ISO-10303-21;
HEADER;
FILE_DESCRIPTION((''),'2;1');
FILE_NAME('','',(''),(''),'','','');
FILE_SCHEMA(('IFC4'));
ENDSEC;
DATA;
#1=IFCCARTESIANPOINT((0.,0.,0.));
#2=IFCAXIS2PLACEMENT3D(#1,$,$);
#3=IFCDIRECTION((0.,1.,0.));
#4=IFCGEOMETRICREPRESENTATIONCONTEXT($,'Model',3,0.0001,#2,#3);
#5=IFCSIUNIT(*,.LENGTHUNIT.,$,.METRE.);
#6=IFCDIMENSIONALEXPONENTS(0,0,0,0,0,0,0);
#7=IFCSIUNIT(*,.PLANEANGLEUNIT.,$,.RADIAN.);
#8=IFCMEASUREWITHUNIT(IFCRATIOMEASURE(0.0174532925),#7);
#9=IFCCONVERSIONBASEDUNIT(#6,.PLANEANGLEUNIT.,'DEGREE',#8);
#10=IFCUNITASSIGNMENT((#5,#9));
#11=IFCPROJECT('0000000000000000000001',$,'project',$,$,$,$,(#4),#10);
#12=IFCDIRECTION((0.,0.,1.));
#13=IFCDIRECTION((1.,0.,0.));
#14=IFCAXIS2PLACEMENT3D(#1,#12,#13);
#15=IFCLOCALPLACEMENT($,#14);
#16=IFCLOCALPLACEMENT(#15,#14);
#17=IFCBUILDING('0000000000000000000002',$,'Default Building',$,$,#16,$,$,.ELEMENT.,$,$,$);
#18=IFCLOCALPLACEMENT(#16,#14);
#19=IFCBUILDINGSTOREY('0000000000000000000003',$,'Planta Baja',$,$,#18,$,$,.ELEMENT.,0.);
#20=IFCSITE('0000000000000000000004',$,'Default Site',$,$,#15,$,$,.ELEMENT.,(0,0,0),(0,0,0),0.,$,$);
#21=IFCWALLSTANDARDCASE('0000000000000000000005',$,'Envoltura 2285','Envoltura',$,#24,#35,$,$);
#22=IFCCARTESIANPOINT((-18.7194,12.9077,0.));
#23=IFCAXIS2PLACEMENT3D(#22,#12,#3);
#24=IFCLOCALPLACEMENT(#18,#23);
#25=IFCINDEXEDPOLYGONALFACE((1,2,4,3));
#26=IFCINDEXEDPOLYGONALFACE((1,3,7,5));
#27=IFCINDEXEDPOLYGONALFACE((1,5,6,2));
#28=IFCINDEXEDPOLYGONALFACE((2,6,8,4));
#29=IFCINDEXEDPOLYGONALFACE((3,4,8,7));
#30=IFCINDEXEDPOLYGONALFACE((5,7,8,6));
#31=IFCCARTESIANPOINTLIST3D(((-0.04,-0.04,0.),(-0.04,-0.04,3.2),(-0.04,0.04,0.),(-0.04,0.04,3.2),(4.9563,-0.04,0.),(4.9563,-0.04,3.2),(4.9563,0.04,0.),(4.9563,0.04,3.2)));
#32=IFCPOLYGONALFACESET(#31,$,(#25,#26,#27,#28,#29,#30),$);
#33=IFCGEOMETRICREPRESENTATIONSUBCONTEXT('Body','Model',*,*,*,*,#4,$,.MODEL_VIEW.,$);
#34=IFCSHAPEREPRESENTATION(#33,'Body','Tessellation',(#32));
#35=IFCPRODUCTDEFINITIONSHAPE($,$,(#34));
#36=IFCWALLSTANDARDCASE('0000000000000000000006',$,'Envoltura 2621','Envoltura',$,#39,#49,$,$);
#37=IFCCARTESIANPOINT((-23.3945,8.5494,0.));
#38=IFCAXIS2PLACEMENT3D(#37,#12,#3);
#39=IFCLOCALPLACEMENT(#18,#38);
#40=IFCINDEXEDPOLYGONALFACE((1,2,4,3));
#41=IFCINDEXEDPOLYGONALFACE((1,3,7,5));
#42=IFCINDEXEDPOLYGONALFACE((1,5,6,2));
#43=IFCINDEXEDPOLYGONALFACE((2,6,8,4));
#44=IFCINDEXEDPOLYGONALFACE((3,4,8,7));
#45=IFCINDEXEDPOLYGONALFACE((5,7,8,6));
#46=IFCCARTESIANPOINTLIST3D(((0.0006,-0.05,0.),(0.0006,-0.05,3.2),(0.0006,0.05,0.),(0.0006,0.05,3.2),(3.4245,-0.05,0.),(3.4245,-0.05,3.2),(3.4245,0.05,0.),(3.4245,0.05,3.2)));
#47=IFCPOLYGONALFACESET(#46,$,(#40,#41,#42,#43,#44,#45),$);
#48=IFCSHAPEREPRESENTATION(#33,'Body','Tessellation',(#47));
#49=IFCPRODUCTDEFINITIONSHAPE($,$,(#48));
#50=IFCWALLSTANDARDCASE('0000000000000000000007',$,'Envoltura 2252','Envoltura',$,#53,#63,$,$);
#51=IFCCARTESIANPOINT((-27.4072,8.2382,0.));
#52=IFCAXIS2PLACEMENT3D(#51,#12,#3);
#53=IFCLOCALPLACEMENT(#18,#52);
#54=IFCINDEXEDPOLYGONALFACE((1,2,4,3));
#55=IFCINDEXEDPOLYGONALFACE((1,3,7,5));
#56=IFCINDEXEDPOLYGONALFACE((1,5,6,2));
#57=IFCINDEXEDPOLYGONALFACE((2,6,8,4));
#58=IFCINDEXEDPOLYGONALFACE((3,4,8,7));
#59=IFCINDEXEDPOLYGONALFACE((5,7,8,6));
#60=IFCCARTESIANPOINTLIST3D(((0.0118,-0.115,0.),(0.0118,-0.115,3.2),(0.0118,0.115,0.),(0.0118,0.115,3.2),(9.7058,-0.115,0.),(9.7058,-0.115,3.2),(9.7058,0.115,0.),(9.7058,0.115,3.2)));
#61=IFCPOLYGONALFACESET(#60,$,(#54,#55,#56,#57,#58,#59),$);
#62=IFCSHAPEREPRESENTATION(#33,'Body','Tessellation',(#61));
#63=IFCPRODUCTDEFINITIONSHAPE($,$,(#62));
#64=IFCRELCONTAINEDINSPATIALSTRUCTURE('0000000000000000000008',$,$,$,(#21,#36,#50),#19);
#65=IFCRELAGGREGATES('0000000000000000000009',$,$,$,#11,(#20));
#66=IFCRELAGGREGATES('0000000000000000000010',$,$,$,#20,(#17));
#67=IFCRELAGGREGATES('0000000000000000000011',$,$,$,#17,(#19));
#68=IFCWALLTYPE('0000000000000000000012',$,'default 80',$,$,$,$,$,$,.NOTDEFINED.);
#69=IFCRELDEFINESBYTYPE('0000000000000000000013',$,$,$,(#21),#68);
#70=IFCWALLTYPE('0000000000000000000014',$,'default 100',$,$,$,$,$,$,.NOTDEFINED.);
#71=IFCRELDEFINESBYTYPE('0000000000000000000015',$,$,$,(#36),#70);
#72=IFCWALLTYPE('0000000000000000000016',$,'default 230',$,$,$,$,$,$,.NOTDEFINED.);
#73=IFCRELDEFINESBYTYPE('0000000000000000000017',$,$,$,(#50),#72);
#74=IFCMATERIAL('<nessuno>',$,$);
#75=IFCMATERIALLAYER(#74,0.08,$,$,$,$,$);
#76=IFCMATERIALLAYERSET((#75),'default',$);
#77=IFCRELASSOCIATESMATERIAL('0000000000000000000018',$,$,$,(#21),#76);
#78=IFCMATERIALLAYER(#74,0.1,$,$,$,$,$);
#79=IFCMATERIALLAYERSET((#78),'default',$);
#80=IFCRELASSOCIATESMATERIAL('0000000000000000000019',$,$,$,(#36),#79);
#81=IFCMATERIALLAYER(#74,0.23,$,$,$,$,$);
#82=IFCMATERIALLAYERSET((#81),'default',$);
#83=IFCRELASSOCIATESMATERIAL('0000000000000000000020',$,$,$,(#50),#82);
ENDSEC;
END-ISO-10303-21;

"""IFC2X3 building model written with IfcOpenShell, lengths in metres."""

from ifc_helpers import new_model, entity, si_unit, converted_unit, direction, frame, origin, origin_with_axes, origin_2d_with_axis, place, context, subcontext, project, spatial, rectangle, extrude, material, layer, layer_set, layer_usage, type_object, element, save


model = new_model("IFC2X3")

# Units and contexts
model_context = context("Model", 3, precision=0.0001, world=origin(), true_north=direction((0.0, 1.0, 0.0)))
body_context = subcontext(model_context, "Body", "Model", "MODEL_VIEW")
ifc_project = project(units=[si_unit("LENGTHUNIT", "METRE"), converted_unit("PLANEANGLEUNIT", "DEGREE", entity("IfcRatioMeasure", 0.0174532925), si_unit("PLANEANGLEUNIT", "RADIAN"), dimensions=[0, 0, 0, 0, 0, 0, 0])], contexts=[model_context])

# Site, building, storey
site_placement = place(None, origin_with_axes())
site = spatial("IfcSite", under=ifc_project, at=site_placement, Name="Default Site", CompositionType="ELEMENT", RefLatitude=(0, 0, 0), RefLongitude=(0, 0, 0), RefElevation=0.0)
building_placement = place(site_placement, origin_with_axes())
building = spatial("IfcBuilding", under=site, at=building_placement, Name="Default Building", CompositionType="ELEMENT")
storey_placement = place(building_placement, origin_with_axes())
storey = spatial("IfcBuildingStorey", under=building, at=storey_placement, Name="Planta Baja", CompositionType="ELEMENT", Elevation=0.0)

# Wall
ifc_material_1 = material(Name="<nessuno>")
ifc_layer_1 = layer(ifc_material_1, 0.08)
ifc_layer_set_1 = layer_set([ifc_layer_1], Name="default")
wall_type_1 = type_object("IfcWallType", Name="default 80", PredefinedType="NOTDEFINED")
ifc_layer_usage_1 = layer_usage(ifc_layer_set_1, "AXIS2", "POSITIVE", -0.04)
wall_1_placement = place(storey_placement, frame((-18.7194, 12.9077, 0.0), z_axis=(0.0, 0.0, 1.0), x_axis=(0.0, 1.0, 0.0)))
element("IfcWallStandardCase", 1, at=wall_1_placement, inside=storey, type_object=wall_type_1, material=ifc_layer_usage_1, Name="Envoltura 2285", Description="Envoltura", context=body_context, shape_type="SweptSolid", body=[
    extrude(rectangle(XDim=0.08, YDim=4.9963, at=origin_2d_with_axis()), frame((2.4582, 0.0, 0.0), z_axis=(0.0, 0.0, 1.0), x_axis=(0.0, -1.0, 0.0)), (0.0, 0.0, 1.0), 3.2),
])

# Wall
ifc_layer_2 = layer(ifc_material_1, 0.1)
ifc_layer_set_2 = layer_set([ifc_layer_2], Name="default")
ifc_layer_usage_2 = layer_usage(ifc_layer_set_2, "AXIS2", "POSITIVE", -0.05)
wall_type_2 = type_object("IfcWallType", Name="default 100", PredefinedType="NOTDEFINED")
wall_2_placement = place(storey_placement, frame((-23.3945, 8.5494, 0.0), z_axis=(0.0, 0.0, 1.0), x_axis=(0.0, 1.0, 0.0)))
element("IfcWallStandardCase", 2, at=wall_2_placement, inside=storey, type_object=wall_type_2, material=ifc_layer_usage_2, Name="Envoltura 2621", Description="Envoltura", context=body_context, shape_type="SweptSolid", body=[
    extrude(rectangle(XDim=0.1, YDim=3.4239, at=origin_2d_with_axis()), frame((1.7125, 0.0, 0.0), z_axis=(0.0, 0.0, 1.0), x_axis=(0.0, -1.0, 0.0)), (0.0, 0.0, 1.0), 3.2),
])

# Wall
ifc_layer_3 = layer(ifc_material_1, 0.23)
ifc_layer_set_3 = layer_set([ifc_layer_3], Name="default")
ifc_layer_usage_3 = layer_usage(ifc_layer_set_3, "AXIS2", "POSITIVE", -0.115)
wall_type_3 = type_object("IfcWallType", Name="default 230", PredefinedType="NOTDEFINED")
wall_3_placement = place(storey_placement, frame((-27.4072, 8.2382, 0.0), z_axis=(0.0, 0.0, 1.0), x_axis=(0.0, 1.0, 0.0)))
element("IfcWallStandardCase", 3, at=wall_3_placement, inside=storey, type_object=wall_type_3, material=ifc_layer_usage_3, Name="Envoltura 2252", Description="Envoltura", context=body_context, shape_type="SweptSolid", body=[
    extrude(rectangle(XDim=0.23, YDim=9.694, at=origin_2d_with_axis()), frame((4.8588, 0.0, 0.0), z_axis=(0.0, 0.0, 1.0), x_axis=(0.0, -1.0, 0.0)), (0.0, 0.0, 1.0), 3.2),
])

save(model, "model.ifc")
